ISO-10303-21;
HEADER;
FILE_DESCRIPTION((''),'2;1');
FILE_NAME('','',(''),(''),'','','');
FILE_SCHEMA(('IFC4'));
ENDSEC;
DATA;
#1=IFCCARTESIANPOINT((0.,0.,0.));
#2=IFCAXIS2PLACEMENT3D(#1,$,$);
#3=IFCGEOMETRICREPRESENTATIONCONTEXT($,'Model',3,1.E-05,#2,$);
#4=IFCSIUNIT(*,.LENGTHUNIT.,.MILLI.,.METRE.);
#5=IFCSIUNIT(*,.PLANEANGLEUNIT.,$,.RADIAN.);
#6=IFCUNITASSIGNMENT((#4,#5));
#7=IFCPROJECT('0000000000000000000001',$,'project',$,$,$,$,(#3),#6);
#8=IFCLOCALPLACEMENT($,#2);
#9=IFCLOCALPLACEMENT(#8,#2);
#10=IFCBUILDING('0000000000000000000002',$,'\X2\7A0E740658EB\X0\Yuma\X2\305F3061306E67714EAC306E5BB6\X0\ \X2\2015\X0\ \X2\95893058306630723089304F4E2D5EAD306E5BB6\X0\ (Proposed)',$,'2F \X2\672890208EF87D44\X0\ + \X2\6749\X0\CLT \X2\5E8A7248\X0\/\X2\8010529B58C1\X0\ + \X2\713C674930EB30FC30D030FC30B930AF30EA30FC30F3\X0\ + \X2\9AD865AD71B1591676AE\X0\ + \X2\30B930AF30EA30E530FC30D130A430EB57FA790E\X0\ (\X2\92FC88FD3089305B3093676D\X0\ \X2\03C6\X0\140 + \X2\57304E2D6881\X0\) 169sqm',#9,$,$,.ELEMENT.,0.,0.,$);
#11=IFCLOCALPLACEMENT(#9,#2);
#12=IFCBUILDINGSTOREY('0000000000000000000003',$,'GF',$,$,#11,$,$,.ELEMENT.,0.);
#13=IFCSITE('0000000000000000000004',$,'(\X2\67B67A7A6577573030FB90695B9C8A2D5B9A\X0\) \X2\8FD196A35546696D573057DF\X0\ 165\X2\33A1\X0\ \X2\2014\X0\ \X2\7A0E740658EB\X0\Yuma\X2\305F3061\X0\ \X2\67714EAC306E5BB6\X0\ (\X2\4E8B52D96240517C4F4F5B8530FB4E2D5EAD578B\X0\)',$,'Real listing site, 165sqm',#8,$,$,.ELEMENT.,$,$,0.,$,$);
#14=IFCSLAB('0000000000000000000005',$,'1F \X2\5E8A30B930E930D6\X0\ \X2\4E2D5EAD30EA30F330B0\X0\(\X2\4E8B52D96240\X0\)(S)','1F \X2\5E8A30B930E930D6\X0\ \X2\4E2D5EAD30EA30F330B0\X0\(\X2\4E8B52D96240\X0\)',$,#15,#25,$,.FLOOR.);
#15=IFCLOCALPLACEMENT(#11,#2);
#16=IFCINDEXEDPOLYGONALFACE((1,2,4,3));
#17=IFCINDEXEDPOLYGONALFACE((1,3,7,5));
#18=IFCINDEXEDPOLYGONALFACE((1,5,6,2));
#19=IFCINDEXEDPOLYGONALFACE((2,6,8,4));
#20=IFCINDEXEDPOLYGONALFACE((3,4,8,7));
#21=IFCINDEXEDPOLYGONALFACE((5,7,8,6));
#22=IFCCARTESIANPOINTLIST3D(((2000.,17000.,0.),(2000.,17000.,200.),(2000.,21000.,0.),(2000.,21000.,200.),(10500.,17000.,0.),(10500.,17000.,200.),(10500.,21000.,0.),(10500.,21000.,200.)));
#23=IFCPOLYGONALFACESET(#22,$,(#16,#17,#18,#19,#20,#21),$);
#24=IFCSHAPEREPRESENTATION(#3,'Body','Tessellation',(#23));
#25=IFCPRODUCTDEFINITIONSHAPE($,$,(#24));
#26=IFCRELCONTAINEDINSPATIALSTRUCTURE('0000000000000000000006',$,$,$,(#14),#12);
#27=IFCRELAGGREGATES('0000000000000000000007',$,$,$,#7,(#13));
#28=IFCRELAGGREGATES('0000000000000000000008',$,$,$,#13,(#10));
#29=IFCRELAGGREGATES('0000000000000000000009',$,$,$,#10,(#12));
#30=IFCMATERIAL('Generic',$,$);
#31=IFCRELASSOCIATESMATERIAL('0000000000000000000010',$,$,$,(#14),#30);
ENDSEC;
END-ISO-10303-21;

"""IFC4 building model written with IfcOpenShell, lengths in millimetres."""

from ifc_helpers import new_model, si_unit, frame, frame_2d, origin, place, context, project, spatial, rectangle, extrude, material, element, save


model = new_model("IFC4")

# Units and contexts
model_context = context("Model", 3, precision=1e-05, world=origin())
ifc_project = project(units=[si_unit("LENGTHUNIT", "METRE", prefix="MILLI"), si_unit("PLANEANGLEUNIT", "RADIAN")], contexts=[model_context])

# Site, building, storey
site_placement = place(None, origin())
site = spatial("IfcSite", under=ifc_project, at=site_placement, Name="(架空敷地・適宜設定) 近隣商業地域 165㎡ — 税理士Yumaたち 東京の家 (事務所兼住宅・中庭型)", ObjectType="Real listing site, 165sqm", CompositionType="ELEMENT", RefElevation=0.0)
building_placement = place(site_placement, origin())
building = spatial("IfcBuilding", under=site, at=building_placement, Name="税理士Yumaたちの東京の家 ― 閉じてひらく中庭の家 (Proposed)", ObjectType="2F 木造軸組 + 杉CLT 床版/耐力壁 + 焼杉ルーバースクリーン + 高断熱外皮 + スクリューパイル基礎 (鋼製らせん杭 φ140 + 地中梁) 169sqm", CompositionType="ELEMENT", ElevationOfRefHeight=0.0, ElevationOfTerrain=0.0)
storey_placement = place(building_placement, origin())
storey = spatial("IfcBuildingStorey", under=building, at=storey_placement, Name="GF", CompositionType="ELEMENT", Elevation=0.0)

# Shared definitions
ifc_material_1 = material(Name="Generic")

# Slab
slab_1_placement = place(storey_placement, frame((1000.0, 8500.0, 0.0)))
element("IfcSlab", 1, at=slab_1_placement, inside=storey, material=ifc_material_1, Name="1F 床スラブ 中庭リング(事務所)(S)", Description="1F 床スラブ 中庭リング(事務所)", PredefinedType="FLOOR", context=model_context, shape_type="SweptSolid", body=[
    extrude(rectangle(XDim=8500.0, YDim=4000.0, at=frame_2d((4250.0, 2000.0))), frame((1000.0, 8500.0, 0.0)), (0.0, 0.0, 1.0), 200.0),
])

save(model, "model.ifc")
